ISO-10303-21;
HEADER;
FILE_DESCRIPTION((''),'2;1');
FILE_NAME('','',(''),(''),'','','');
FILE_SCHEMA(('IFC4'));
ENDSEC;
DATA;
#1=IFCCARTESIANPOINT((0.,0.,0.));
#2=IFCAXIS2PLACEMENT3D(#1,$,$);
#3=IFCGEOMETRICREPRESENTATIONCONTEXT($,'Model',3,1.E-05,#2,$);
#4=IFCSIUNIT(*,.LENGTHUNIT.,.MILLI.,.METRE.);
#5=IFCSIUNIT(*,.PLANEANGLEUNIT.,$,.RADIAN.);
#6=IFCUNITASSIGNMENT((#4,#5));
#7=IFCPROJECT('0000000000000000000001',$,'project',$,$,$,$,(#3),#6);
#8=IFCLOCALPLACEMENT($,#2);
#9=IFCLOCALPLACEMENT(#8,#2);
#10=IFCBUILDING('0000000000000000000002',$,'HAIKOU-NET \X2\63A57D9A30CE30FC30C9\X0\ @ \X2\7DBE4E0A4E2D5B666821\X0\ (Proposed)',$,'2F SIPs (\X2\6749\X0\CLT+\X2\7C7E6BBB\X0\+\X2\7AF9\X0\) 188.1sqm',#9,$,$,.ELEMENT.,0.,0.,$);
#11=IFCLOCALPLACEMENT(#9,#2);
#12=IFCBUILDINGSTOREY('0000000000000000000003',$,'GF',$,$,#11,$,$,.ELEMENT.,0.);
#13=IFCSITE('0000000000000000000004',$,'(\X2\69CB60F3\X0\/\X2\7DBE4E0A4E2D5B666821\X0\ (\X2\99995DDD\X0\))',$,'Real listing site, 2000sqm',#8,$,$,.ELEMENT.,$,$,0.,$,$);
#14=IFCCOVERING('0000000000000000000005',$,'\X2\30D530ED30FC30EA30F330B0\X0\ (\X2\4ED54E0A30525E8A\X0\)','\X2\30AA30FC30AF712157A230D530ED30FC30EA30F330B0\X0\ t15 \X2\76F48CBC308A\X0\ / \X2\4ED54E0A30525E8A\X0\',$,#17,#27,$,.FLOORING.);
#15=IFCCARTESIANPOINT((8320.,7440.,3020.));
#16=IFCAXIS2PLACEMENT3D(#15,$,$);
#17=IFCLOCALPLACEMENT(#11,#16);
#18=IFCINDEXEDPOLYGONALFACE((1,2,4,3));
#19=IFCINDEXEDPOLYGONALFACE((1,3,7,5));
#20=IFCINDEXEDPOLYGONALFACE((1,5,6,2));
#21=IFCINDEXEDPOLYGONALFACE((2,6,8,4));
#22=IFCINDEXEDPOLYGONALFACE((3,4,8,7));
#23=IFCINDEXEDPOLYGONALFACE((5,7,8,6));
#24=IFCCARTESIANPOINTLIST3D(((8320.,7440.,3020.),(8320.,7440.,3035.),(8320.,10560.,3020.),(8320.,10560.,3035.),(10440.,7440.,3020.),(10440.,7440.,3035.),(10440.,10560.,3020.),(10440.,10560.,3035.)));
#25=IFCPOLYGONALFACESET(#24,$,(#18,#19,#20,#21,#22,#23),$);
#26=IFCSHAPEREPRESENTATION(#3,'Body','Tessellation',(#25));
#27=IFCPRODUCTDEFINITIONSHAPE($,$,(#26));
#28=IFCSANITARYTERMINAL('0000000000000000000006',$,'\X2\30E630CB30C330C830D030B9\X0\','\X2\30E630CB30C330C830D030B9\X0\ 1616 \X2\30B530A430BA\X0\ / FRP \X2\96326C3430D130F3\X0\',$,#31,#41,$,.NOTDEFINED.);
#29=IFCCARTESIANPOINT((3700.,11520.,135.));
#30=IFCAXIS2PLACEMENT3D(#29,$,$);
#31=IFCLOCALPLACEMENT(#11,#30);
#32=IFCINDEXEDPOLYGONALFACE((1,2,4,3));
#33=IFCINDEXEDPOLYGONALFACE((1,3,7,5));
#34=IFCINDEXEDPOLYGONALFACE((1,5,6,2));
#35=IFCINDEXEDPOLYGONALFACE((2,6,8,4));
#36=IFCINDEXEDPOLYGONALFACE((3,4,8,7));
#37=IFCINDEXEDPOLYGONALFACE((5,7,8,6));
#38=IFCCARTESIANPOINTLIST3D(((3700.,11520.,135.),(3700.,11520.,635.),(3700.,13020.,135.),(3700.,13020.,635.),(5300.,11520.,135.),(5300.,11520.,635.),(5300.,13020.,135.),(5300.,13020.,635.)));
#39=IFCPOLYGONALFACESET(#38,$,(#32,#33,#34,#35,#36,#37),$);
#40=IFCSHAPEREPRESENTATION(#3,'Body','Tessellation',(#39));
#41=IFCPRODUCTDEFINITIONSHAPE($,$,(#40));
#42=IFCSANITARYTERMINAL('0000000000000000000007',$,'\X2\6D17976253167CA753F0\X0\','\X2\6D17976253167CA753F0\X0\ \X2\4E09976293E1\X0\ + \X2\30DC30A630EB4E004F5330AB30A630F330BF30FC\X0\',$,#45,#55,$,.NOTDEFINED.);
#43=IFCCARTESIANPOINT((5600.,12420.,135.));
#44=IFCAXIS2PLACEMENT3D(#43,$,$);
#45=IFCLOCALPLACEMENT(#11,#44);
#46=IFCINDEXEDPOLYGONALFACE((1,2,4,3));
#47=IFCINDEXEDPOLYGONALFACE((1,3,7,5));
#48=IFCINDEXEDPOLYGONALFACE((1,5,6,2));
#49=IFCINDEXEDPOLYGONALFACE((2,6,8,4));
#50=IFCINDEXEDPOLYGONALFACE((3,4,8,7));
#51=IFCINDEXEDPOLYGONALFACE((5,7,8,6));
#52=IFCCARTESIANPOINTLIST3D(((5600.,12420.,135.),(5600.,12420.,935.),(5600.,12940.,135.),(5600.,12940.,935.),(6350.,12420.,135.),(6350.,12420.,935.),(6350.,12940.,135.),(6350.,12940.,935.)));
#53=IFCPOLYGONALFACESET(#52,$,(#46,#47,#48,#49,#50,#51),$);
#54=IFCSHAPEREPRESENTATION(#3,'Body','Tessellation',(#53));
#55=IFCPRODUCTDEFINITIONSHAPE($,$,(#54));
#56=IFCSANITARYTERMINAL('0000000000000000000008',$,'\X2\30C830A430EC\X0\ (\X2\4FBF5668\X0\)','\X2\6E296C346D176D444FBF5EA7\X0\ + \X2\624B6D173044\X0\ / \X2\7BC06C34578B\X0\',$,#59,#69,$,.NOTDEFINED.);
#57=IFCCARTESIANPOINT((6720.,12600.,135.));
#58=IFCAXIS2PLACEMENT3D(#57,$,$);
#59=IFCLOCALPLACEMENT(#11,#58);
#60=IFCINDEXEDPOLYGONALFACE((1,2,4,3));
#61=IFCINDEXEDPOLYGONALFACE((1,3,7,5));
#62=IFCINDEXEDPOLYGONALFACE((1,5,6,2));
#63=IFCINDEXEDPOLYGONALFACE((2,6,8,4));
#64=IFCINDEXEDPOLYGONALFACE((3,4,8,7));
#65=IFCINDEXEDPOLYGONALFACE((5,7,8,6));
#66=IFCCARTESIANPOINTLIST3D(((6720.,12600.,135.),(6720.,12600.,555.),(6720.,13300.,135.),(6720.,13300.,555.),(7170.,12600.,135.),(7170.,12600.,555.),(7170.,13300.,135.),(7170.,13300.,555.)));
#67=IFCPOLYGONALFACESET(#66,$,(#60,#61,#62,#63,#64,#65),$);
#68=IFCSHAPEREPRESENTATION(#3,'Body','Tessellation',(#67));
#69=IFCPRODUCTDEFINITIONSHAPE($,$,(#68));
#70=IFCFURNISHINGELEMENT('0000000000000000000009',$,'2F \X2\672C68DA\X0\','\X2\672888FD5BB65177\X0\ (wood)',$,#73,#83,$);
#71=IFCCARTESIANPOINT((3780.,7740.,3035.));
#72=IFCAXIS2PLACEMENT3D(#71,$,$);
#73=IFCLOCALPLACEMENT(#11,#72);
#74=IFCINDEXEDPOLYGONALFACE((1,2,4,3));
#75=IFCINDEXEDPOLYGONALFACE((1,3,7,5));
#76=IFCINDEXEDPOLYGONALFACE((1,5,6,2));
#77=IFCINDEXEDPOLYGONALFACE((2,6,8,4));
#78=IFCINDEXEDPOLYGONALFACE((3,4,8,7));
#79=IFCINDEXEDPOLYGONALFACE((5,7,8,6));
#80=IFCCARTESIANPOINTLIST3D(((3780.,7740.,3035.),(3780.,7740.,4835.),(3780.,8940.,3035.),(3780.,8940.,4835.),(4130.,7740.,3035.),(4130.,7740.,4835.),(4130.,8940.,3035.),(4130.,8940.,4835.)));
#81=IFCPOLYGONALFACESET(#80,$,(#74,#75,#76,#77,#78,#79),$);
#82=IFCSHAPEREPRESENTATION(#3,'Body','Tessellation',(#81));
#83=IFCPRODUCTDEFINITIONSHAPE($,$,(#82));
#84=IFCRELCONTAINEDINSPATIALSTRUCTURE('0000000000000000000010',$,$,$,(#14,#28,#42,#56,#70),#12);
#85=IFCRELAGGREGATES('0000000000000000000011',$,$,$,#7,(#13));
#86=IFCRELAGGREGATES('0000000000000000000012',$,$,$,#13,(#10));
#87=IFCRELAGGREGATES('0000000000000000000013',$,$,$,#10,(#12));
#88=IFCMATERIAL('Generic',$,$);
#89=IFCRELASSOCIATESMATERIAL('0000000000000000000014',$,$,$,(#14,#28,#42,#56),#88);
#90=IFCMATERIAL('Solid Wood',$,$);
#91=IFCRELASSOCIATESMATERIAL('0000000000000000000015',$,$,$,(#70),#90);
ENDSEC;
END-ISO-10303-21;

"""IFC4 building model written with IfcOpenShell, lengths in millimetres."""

from ifc_helpers import new_model, si_unit, frame, frame_2d, origin, place, context, project, spatial, rectangle, extrude, material, element, save


model = new_model("IFC4")

# Units and contexts
model_context = context("Model", 3, precision=1e-05, world=origin())
ifc_project = project(units=[si_unit("LENGTHUNIT", "METRE", prefix="MILLI"), si_unit("PLANEANGLEUNIT", "RADIAN")], contexts=[model_context])

# Site, building, storey
site_placement = place(None, origin())
site = spatial("IfcSite", under=ifc_project, at=site_placement, Name="(構想/綾上中学校 (香川))", ObjectType="Real listing site, 2000sqm", CompositionType="ELEMENT", RefElevation=0.0)
building_placement = place(site_placement, origin())
building = spatial("IfcBuilding", under=site, at=building_placement, Name="HAIKOU-NET 接続ノード @ 綾上中学校 (Proposed)", ObjectType="2F SIPs (杉CLT+籾殻+竹) 188.1sqm", CompositionType="ELEMENT", ElevationOfRefHeight=0.0, ElevationOfTerrain=0.0)
storey_placement = place(building_placement, origin())
storey = spatial("IfcBuildingStorey", under=building, at=storey_placement, Name="GF", CompositionType="ELEMENT", Elevation=0.0)

# Shared definitions
ifc_material_1 = material(Name="Solid Wood")
ifc_material_2 = material(Name="Generic")

# Covering
covering_1_placement = place(storey_placement, frame((8320.0, 7440.0, 3020.0)))
element("IfcCovering", 1, at=covering_1_placement, inside=storey, material=ifc_material_2, Name="フローリング (仕上げ床)", Description="オーク無垢フローリング t15 直貼り / 仕上げ床", PredefinedType="FLOORING", context=model_context, shape_type="SweptSolid", body=[
    extrude(rectangle(XDim=2120.0, YDim=3120.0, at=frame_2d((1060.0, 1560.0))), frame((8320.0, 7440.0, 3020.0)), (0.0, 0.0, 1.0), 15.0),
])

# Sanitary terminals
sanitary_terminal_1_placement = place(storey_placement, frame((3700.0, 11520.0, 135.0)))
element("IfcSanitaryTerminal", 2, at=sanitary_terminal_1_placement, inside=storey, material=ifc_material_2, Name="ユニットバス", Description="ユニットバス 1616 サイズ / FRP 防水パン", PredefinedType="NOTDEFINED", context=model_context, shape_type="SweptSolid", body=[
    extrude(rectangle(XDim=1600.0, YDim=1500.0, at=frame_2d((800.0, 750.0))), frame((3700.0, 11520.0, 135.0)), (0.0, 0.0, 1.0), 500.0),
])
sanitary_terminal_2_placement = place(storey_placement, frame((5600.0, 12420.0, 135.0)))
element("IfcSanitaryTerminal", 3, at=sanitary_terminal_2_placement, inside=storey, material=ifc_material_2, Name="洗面化粧台", Description="洗面化粧台 三面鏡 + ボウル一体カウンター", PredefinedType="NOTDEFINED", context=model_context, shape_type="SweptSolid", body=[
    extrude(rectangle(XDim=750.0, YDim=520.0, at=frame_2d((375.0, 260.0))), frame((5600.0, 12420.0, 135.0)), (0.0, 0.0, 1.0), 800.0),
])
sanitary_terminal_3_placement = place(storey_placement, frame((6720.0, 12600.0, 135.0)))
element("IfcSanitaryTerminal", 4, at=sanitary_terminal_3_placement, inside=storey, material=ifc_material_2, Name="トイレ (便器)", Description="温水洗浄便座 + 手洗い / 節水型", PredefinedType="NOTDEFINED", context=model_context, shape_type="SweptSolid", body=[
    extrude(rectangle(XDim=450.0, YDim=700.0, at=frame_2d((225.0, 350.0))), frame((6720.0, 12600.0, 135.0)), (0.0, 0.0, 1.0), 420.0),
])

# Furnishing element
furnishing_placement = place(storey_placement, frame((3780.0, 7740.0, 3035.0)))
element("IfcFurnishingElement", 5, at=furnishing_placement, inside=storey, material=ifc_material_1, Name="2F 本棚", Description="木製家具 (wood)", context=model_context, shape_type="SweptSolid", body=[
    extrude(rectangle(XDim=350.0, YDim=1200.0, at=frame_2d((175.0, 600.0))), frame((3780.0, 7740.0, 3035.0)), (0.0, 0.0, 1.0), 1800.0),
])

save(model, "model.ifc")
